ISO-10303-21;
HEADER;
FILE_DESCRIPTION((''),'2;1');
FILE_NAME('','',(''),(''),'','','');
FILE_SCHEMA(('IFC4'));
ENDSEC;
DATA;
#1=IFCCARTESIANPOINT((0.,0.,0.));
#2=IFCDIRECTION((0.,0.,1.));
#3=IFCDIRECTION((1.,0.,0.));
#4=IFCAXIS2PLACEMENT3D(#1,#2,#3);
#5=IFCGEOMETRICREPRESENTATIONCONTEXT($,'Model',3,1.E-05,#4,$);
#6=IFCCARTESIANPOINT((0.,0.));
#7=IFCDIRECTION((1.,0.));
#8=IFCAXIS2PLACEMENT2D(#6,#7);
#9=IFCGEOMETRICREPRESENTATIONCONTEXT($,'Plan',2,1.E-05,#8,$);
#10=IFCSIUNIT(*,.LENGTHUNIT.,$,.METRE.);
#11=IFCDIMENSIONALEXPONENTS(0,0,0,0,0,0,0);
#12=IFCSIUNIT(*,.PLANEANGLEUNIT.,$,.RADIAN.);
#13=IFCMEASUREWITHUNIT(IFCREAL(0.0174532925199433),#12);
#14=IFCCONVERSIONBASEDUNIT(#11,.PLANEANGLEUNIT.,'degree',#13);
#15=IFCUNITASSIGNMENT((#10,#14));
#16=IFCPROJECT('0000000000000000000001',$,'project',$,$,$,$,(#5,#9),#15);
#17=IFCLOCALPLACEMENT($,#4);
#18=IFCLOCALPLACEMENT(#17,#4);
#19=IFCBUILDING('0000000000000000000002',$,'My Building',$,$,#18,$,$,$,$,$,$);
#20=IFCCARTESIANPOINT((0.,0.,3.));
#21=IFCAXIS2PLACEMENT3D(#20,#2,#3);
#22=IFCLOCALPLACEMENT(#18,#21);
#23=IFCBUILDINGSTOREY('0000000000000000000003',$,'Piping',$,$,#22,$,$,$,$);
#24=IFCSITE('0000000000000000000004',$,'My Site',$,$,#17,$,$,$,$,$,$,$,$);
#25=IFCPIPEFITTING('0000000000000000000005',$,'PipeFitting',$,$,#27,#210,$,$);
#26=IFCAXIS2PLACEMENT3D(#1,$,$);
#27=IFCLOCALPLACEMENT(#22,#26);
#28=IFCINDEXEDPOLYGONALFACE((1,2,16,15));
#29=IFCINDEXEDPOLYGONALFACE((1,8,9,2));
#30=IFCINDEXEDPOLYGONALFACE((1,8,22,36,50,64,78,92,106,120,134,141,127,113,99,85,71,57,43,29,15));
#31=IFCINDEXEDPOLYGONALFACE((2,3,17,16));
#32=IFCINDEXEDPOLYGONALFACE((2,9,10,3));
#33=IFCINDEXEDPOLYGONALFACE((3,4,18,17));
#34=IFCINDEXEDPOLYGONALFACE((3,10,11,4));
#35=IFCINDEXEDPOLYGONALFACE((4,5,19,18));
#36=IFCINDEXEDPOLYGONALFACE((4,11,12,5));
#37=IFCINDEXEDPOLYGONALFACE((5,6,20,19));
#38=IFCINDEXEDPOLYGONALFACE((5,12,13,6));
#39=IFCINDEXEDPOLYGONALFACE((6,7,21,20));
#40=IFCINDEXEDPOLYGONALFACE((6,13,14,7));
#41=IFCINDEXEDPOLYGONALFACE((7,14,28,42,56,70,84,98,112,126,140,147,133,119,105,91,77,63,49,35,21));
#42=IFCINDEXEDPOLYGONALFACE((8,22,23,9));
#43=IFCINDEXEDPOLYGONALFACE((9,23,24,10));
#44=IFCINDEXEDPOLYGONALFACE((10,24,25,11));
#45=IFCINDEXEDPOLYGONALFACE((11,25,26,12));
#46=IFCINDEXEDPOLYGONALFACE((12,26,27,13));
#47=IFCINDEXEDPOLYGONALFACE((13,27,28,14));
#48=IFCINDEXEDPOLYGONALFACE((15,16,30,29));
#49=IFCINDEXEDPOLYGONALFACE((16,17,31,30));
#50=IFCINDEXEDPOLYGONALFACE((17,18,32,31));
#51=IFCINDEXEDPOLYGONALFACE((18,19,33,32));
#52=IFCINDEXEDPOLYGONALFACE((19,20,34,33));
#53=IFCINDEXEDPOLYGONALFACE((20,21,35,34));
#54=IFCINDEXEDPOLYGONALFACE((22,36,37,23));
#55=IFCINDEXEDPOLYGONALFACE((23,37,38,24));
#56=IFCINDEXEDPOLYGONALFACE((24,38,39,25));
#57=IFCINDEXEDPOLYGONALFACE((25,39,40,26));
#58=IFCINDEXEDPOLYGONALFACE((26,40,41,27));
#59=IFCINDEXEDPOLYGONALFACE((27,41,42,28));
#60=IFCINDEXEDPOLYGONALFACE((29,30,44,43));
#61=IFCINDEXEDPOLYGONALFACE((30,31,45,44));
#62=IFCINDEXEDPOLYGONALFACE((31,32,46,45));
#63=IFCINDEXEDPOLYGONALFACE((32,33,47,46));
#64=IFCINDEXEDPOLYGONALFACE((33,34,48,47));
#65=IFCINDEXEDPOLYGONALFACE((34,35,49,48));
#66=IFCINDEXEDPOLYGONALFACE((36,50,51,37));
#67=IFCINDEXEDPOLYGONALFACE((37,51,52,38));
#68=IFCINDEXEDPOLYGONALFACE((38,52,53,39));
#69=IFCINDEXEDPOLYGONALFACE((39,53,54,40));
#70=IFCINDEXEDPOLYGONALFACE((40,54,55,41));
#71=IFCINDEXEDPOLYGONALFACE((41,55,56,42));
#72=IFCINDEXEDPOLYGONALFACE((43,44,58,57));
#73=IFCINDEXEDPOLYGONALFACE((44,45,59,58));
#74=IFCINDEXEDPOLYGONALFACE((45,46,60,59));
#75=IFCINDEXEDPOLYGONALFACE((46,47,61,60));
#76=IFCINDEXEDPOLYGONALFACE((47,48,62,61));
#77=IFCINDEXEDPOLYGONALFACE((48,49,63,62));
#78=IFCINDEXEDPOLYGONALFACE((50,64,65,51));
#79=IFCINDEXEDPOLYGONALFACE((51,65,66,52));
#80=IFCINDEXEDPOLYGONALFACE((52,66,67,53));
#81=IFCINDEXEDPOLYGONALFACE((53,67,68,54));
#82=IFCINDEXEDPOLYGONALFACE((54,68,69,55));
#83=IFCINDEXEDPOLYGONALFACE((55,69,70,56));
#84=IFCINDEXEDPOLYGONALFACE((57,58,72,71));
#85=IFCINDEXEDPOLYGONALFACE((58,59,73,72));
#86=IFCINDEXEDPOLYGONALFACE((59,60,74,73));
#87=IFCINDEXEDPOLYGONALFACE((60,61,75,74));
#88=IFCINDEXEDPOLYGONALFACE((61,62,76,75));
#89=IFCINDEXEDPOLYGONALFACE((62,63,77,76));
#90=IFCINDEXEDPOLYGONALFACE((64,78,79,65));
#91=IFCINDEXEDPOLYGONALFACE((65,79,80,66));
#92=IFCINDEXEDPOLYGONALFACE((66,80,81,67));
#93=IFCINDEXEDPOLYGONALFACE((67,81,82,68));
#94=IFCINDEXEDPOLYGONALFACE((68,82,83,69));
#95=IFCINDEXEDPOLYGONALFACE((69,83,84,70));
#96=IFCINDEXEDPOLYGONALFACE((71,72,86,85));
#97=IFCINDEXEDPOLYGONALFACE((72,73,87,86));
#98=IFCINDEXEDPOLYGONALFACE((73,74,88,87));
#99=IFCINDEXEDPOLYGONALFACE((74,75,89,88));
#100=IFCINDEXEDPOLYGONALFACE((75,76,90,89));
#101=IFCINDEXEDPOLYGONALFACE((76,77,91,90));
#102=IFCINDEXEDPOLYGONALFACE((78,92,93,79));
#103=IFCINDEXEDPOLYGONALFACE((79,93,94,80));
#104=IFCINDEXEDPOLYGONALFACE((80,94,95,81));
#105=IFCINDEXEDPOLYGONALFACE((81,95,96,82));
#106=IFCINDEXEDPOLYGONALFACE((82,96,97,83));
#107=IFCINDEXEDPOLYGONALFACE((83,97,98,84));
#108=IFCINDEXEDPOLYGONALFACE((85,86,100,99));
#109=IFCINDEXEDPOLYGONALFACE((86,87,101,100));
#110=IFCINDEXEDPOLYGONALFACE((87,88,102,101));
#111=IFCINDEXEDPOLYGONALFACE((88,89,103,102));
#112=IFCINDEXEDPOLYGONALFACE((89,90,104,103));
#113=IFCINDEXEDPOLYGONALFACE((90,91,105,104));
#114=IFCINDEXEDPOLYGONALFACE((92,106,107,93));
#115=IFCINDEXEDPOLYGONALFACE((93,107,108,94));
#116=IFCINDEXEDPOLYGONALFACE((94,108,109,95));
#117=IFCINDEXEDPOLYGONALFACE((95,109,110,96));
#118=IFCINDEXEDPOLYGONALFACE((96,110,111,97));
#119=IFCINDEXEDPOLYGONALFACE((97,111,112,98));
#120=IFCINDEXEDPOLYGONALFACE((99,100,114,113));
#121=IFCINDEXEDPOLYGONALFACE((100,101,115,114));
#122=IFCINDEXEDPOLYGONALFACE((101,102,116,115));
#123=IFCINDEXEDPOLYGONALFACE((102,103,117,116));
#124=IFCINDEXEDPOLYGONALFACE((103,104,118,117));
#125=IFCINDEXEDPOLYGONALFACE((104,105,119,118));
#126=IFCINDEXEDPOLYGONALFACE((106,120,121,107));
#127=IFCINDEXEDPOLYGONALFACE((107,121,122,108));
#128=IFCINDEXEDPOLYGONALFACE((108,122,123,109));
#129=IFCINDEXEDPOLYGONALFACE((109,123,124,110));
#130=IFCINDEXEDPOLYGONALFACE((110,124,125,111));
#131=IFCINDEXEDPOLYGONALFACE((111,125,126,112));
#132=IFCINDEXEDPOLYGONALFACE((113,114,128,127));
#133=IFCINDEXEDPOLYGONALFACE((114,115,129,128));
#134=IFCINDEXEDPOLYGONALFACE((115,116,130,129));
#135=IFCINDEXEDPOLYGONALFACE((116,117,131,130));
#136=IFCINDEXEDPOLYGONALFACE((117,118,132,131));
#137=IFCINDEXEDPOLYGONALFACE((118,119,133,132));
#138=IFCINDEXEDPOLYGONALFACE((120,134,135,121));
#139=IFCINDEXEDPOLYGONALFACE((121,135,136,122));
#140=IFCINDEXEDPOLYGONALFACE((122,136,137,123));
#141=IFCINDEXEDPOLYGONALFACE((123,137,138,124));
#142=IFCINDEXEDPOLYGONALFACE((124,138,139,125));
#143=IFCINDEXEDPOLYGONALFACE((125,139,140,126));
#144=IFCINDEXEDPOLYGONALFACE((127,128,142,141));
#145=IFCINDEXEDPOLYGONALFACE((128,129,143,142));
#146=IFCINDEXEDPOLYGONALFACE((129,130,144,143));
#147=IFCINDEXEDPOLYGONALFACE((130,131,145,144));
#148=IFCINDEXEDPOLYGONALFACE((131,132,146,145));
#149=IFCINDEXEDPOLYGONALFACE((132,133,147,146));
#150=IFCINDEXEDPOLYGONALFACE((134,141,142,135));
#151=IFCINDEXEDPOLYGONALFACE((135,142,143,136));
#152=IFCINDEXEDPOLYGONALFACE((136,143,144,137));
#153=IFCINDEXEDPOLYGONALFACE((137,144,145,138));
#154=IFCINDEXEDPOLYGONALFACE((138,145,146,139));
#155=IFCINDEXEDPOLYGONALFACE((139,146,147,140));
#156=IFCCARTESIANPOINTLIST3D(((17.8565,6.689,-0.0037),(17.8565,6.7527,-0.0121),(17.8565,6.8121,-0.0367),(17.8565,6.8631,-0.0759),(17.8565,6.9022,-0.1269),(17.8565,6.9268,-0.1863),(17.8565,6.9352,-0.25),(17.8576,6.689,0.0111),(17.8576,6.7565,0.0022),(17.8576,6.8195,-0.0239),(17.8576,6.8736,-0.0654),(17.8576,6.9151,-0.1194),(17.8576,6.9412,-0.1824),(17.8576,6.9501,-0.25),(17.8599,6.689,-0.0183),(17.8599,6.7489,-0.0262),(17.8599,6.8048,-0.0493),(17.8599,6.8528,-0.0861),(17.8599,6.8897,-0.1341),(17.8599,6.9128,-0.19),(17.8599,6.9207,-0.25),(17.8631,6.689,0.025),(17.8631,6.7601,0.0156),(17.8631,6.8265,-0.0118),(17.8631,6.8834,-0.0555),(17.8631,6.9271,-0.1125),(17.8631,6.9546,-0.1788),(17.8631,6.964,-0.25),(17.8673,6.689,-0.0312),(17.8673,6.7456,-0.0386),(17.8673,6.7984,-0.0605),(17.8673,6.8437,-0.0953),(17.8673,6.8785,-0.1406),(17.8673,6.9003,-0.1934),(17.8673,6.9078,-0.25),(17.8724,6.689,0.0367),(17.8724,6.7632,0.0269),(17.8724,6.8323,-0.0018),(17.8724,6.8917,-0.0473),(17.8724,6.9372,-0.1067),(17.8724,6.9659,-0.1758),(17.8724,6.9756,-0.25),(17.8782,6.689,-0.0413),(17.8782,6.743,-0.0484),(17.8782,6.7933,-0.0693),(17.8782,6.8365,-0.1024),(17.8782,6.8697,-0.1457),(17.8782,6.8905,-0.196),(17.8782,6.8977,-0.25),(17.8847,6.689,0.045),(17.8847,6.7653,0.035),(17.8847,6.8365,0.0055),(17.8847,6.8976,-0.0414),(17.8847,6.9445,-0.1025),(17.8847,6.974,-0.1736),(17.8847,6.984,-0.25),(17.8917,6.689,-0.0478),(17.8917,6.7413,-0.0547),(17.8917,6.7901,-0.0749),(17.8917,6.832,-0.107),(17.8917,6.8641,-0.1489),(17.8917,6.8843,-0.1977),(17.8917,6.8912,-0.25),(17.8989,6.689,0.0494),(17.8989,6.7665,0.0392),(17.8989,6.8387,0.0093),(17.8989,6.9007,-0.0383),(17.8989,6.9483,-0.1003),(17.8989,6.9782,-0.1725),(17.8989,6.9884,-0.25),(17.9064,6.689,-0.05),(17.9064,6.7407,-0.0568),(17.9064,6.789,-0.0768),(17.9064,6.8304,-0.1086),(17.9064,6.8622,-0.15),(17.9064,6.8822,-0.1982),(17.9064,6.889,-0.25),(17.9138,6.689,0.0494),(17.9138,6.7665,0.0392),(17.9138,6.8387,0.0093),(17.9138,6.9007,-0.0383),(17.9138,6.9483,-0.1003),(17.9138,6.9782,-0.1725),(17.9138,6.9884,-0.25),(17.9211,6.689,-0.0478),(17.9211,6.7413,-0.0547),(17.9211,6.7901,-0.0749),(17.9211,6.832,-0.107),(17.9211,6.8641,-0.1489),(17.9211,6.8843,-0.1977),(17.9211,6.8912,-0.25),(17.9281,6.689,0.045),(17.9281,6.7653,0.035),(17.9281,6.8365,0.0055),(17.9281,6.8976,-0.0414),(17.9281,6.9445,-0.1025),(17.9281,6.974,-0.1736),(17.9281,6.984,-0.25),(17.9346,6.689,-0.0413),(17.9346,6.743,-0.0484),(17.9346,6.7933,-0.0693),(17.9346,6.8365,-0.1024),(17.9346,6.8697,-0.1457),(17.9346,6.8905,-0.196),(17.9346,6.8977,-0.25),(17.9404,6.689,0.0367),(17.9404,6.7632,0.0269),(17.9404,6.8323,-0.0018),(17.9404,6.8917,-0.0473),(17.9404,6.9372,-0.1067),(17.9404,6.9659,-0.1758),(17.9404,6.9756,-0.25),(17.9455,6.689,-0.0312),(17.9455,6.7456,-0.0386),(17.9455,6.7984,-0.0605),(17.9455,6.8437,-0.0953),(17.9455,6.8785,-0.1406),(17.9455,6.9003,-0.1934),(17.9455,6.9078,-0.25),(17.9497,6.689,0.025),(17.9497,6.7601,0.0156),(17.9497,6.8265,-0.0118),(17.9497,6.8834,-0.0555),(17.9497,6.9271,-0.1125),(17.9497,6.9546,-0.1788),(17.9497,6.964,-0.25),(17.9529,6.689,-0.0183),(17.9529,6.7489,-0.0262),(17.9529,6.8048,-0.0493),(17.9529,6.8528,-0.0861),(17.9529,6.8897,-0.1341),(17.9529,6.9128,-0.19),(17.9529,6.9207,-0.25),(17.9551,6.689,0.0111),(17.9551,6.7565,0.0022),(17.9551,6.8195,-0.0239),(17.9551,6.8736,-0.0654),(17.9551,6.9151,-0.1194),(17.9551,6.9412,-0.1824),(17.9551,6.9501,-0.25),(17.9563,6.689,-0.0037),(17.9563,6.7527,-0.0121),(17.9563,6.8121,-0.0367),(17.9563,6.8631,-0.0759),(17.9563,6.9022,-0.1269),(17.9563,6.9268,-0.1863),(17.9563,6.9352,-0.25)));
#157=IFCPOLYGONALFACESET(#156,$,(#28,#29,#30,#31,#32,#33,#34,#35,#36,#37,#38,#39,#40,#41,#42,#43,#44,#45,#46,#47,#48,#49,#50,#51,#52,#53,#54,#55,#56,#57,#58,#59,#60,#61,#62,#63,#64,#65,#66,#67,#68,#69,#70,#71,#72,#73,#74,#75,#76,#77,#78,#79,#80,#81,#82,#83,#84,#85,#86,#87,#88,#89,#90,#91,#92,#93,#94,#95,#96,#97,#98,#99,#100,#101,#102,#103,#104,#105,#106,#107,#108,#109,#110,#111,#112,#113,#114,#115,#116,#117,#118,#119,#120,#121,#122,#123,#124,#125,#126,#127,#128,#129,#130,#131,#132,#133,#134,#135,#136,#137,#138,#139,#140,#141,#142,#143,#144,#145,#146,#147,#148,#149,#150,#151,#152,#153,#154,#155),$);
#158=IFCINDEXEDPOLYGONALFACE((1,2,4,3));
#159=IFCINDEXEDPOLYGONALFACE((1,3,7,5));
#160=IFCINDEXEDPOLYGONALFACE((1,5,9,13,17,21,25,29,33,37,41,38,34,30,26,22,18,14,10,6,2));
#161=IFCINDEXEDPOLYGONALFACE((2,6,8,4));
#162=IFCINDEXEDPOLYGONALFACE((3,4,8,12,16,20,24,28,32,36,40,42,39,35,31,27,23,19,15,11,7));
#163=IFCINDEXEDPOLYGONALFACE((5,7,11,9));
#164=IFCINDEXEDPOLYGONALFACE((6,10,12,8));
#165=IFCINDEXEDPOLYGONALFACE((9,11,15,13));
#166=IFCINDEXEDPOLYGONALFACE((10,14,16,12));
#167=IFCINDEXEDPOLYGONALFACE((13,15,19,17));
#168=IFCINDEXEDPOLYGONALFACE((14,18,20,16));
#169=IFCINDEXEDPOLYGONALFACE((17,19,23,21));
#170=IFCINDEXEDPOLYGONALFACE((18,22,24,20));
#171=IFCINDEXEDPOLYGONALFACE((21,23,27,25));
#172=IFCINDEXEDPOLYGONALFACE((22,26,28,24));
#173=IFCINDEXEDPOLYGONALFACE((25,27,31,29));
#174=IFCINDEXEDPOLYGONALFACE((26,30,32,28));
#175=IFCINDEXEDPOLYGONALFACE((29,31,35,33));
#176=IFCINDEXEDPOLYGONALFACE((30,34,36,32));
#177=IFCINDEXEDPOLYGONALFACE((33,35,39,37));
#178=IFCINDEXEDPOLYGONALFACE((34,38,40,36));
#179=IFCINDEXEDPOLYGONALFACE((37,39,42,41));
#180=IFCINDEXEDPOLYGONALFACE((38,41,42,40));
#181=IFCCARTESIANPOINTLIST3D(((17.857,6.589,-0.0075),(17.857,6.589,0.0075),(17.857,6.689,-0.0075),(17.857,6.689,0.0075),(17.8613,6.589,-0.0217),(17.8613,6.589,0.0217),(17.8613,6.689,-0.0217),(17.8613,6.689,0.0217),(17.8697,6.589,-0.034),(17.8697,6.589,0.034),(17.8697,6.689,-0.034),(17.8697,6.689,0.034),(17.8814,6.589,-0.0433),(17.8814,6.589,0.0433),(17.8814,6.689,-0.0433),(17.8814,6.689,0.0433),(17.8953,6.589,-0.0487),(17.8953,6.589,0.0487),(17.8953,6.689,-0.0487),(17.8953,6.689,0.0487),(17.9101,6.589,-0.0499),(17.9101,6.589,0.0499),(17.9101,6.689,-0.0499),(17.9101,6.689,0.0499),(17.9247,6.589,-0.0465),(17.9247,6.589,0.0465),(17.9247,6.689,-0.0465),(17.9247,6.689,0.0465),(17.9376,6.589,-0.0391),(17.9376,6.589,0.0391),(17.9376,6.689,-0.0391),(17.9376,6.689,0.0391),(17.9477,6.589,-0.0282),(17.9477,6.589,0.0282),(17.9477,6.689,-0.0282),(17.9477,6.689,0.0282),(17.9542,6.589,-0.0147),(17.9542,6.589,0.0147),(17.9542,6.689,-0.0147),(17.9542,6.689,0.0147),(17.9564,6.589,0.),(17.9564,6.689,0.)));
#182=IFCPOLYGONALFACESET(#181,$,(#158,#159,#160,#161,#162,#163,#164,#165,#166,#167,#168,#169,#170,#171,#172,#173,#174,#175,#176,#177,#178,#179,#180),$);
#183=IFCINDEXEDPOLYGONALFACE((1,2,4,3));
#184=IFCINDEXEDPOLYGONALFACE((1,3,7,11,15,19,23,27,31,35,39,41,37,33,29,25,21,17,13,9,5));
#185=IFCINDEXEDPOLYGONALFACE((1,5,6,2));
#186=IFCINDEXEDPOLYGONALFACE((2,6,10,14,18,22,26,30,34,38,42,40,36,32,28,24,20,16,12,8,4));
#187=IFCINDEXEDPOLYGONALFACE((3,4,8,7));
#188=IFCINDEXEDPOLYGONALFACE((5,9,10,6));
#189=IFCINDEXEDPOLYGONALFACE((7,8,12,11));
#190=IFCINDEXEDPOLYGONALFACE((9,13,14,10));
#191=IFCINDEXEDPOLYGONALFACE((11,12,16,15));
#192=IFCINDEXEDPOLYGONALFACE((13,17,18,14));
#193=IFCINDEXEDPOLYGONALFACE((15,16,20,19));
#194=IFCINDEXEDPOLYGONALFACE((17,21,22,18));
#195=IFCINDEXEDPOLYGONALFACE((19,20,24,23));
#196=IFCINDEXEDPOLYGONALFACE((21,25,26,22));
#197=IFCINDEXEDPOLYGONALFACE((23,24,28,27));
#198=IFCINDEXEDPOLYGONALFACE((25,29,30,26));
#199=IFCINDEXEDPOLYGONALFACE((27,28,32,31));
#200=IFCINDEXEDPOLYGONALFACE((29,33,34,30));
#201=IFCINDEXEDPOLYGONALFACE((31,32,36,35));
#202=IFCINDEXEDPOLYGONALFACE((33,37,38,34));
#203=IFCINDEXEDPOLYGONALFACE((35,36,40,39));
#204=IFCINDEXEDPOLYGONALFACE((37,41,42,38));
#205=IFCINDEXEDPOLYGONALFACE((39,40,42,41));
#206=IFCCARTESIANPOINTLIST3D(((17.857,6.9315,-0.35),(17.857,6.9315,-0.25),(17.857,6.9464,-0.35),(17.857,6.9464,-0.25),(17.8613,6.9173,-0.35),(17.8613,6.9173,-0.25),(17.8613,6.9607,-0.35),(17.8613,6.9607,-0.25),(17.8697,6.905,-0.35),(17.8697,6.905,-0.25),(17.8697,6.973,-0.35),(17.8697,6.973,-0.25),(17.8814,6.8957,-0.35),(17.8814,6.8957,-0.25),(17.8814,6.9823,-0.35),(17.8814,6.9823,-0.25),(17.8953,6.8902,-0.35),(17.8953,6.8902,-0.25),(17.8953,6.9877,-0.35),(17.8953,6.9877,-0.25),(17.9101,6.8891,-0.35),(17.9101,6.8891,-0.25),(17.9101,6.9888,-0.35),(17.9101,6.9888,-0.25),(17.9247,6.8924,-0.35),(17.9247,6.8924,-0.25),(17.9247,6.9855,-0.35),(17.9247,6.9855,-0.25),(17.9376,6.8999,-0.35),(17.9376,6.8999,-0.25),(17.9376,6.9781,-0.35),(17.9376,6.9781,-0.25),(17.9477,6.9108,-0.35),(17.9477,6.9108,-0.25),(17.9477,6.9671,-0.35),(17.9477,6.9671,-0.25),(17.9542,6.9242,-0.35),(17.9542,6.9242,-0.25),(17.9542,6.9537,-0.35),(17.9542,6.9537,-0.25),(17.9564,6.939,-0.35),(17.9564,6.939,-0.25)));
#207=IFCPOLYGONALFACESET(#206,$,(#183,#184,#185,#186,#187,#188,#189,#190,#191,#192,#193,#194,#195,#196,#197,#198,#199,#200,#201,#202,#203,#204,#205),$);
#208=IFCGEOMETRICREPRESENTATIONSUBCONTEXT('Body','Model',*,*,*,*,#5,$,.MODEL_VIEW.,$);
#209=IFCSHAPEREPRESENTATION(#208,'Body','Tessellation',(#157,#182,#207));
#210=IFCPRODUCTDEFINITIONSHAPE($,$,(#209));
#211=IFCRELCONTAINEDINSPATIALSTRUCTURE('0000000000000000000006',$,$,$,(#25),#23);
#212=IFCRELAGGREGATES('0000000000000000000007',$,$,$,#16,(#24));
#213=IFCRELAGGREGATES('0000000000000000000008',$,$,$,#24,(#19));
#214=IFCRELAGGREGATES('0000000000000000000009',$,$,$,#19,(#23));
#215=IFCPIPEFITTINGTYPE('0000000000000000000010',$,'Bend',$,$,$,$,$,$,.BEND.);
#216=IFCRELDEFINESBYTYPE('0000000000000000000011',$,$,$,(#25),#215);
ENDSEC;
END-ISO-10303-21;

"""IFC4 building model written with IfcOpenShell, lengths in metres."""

from ifc_helpers import new_model, entity, si_unit, converted_unit, frame, origin_with_axes, origin_2d_with_axis, place, context, subcontext, project, spatial, circle, extrude, source, transform, mapped, type_object, type_shapes, element, save


model = new_model("IFC4")

# Units and contexts
model_context = context("Model", 3, precision=1e-05, world=origin_with_axes())
plan_context = context("Plan", 2, precision=1e-05, world=origin_2d_with_axis())
body_context = subcontext(model_context, "Body", "Model", "MODEL_VIEW")
ifc_project = project(units=[si_unit("LENGTHUNIT", "METRE"), converted_unit("PLANEANGLEUNIT", "degree", entity("IfcReal", 0.0174532925199433), si_unit("PLANEANGLEUNIT", "RADIAN"), dimensions=[0, 0, 0, 0, 0, 0, 0])], contexts=[model_context, plan_context])

# Site, building, storey
site_placement = place(None, origin_with_axes())
site = spatial("IfcSite", under=ifc_project, at=site_placement, Name="My Site")
building_placement = place(site_placement, origin_with_axes())
building = spatial("IfcBuilding", under=site, at=building_placement, Name="My Building")
storey_placement = place(building_placement, frame((0.0, 0.0, 3.0), z_axis=(0.0, 0.0, 1.0), x_axis=(1.0, 0.0, 0.0)))
storey = spatial("IfcBuildingStorey", under=building, at=storey_placement, Name="Piping")

# Pipe fitting
pipe_fitting_type_1 = type_object("IfcPipeFittingType", Name="Bend", PredefinedType="BEND")
shared_shape = source(origin_with_axes(), body_context, "Body", "SolidModel", [
    entity("IfcSweptDiskSolid", entity("IfcIndexedPolyCurve", entity("IfcCartesianPointList3D", [[0.0, 0.0, -0.1], [0.0, -0.0732, -0.2768], [0.0, -0.25, -0.35]]), [entity("IfcArcIndex", [1, 2, 3])]), 0.05),
    extrude(circle(Radius=0.05), origin_with_axes(), (0.0, 0.0, -1.0), 0.1),
    extrude(circle(Radius=0.05), frame((0.0, -0.25, -0.35), z_axis=(0.0, -1.0, 0.0), x_axis=(1.0, 0.0, 0.0)), (0.0, 0.0, 1.0), 0.1),
])
type_shapes(pipe_fitting_type_1, [shared_shape])
for number, where, z_axis, x_axis, name in (
    (1, (17.9064, 6.589, 0.0), (0.0, -1.0, 0.0), (1.0, 0.0, 0.0), "PipeFitting"),
):
    element("IfcPipeFitting", number, at=place(storey_placement, frame(where, z_axis=z_axis, x_axis=x_axis)), inside=storey, type_object=pipe_fitting_type_1, Name=name, context=body_context, shape_type="MappedRepresentation", body=[
        mapped(shared_shape, transform((0.0, 0.0, 0.0), x_axis=(1.0, 0.0, 0.0), y_axis=(0.0, 1.0, 0.0), z_axis=(0.0, 0.0, 1.0), scale=1.0)),
    ])

save(model, "model.ifc")
